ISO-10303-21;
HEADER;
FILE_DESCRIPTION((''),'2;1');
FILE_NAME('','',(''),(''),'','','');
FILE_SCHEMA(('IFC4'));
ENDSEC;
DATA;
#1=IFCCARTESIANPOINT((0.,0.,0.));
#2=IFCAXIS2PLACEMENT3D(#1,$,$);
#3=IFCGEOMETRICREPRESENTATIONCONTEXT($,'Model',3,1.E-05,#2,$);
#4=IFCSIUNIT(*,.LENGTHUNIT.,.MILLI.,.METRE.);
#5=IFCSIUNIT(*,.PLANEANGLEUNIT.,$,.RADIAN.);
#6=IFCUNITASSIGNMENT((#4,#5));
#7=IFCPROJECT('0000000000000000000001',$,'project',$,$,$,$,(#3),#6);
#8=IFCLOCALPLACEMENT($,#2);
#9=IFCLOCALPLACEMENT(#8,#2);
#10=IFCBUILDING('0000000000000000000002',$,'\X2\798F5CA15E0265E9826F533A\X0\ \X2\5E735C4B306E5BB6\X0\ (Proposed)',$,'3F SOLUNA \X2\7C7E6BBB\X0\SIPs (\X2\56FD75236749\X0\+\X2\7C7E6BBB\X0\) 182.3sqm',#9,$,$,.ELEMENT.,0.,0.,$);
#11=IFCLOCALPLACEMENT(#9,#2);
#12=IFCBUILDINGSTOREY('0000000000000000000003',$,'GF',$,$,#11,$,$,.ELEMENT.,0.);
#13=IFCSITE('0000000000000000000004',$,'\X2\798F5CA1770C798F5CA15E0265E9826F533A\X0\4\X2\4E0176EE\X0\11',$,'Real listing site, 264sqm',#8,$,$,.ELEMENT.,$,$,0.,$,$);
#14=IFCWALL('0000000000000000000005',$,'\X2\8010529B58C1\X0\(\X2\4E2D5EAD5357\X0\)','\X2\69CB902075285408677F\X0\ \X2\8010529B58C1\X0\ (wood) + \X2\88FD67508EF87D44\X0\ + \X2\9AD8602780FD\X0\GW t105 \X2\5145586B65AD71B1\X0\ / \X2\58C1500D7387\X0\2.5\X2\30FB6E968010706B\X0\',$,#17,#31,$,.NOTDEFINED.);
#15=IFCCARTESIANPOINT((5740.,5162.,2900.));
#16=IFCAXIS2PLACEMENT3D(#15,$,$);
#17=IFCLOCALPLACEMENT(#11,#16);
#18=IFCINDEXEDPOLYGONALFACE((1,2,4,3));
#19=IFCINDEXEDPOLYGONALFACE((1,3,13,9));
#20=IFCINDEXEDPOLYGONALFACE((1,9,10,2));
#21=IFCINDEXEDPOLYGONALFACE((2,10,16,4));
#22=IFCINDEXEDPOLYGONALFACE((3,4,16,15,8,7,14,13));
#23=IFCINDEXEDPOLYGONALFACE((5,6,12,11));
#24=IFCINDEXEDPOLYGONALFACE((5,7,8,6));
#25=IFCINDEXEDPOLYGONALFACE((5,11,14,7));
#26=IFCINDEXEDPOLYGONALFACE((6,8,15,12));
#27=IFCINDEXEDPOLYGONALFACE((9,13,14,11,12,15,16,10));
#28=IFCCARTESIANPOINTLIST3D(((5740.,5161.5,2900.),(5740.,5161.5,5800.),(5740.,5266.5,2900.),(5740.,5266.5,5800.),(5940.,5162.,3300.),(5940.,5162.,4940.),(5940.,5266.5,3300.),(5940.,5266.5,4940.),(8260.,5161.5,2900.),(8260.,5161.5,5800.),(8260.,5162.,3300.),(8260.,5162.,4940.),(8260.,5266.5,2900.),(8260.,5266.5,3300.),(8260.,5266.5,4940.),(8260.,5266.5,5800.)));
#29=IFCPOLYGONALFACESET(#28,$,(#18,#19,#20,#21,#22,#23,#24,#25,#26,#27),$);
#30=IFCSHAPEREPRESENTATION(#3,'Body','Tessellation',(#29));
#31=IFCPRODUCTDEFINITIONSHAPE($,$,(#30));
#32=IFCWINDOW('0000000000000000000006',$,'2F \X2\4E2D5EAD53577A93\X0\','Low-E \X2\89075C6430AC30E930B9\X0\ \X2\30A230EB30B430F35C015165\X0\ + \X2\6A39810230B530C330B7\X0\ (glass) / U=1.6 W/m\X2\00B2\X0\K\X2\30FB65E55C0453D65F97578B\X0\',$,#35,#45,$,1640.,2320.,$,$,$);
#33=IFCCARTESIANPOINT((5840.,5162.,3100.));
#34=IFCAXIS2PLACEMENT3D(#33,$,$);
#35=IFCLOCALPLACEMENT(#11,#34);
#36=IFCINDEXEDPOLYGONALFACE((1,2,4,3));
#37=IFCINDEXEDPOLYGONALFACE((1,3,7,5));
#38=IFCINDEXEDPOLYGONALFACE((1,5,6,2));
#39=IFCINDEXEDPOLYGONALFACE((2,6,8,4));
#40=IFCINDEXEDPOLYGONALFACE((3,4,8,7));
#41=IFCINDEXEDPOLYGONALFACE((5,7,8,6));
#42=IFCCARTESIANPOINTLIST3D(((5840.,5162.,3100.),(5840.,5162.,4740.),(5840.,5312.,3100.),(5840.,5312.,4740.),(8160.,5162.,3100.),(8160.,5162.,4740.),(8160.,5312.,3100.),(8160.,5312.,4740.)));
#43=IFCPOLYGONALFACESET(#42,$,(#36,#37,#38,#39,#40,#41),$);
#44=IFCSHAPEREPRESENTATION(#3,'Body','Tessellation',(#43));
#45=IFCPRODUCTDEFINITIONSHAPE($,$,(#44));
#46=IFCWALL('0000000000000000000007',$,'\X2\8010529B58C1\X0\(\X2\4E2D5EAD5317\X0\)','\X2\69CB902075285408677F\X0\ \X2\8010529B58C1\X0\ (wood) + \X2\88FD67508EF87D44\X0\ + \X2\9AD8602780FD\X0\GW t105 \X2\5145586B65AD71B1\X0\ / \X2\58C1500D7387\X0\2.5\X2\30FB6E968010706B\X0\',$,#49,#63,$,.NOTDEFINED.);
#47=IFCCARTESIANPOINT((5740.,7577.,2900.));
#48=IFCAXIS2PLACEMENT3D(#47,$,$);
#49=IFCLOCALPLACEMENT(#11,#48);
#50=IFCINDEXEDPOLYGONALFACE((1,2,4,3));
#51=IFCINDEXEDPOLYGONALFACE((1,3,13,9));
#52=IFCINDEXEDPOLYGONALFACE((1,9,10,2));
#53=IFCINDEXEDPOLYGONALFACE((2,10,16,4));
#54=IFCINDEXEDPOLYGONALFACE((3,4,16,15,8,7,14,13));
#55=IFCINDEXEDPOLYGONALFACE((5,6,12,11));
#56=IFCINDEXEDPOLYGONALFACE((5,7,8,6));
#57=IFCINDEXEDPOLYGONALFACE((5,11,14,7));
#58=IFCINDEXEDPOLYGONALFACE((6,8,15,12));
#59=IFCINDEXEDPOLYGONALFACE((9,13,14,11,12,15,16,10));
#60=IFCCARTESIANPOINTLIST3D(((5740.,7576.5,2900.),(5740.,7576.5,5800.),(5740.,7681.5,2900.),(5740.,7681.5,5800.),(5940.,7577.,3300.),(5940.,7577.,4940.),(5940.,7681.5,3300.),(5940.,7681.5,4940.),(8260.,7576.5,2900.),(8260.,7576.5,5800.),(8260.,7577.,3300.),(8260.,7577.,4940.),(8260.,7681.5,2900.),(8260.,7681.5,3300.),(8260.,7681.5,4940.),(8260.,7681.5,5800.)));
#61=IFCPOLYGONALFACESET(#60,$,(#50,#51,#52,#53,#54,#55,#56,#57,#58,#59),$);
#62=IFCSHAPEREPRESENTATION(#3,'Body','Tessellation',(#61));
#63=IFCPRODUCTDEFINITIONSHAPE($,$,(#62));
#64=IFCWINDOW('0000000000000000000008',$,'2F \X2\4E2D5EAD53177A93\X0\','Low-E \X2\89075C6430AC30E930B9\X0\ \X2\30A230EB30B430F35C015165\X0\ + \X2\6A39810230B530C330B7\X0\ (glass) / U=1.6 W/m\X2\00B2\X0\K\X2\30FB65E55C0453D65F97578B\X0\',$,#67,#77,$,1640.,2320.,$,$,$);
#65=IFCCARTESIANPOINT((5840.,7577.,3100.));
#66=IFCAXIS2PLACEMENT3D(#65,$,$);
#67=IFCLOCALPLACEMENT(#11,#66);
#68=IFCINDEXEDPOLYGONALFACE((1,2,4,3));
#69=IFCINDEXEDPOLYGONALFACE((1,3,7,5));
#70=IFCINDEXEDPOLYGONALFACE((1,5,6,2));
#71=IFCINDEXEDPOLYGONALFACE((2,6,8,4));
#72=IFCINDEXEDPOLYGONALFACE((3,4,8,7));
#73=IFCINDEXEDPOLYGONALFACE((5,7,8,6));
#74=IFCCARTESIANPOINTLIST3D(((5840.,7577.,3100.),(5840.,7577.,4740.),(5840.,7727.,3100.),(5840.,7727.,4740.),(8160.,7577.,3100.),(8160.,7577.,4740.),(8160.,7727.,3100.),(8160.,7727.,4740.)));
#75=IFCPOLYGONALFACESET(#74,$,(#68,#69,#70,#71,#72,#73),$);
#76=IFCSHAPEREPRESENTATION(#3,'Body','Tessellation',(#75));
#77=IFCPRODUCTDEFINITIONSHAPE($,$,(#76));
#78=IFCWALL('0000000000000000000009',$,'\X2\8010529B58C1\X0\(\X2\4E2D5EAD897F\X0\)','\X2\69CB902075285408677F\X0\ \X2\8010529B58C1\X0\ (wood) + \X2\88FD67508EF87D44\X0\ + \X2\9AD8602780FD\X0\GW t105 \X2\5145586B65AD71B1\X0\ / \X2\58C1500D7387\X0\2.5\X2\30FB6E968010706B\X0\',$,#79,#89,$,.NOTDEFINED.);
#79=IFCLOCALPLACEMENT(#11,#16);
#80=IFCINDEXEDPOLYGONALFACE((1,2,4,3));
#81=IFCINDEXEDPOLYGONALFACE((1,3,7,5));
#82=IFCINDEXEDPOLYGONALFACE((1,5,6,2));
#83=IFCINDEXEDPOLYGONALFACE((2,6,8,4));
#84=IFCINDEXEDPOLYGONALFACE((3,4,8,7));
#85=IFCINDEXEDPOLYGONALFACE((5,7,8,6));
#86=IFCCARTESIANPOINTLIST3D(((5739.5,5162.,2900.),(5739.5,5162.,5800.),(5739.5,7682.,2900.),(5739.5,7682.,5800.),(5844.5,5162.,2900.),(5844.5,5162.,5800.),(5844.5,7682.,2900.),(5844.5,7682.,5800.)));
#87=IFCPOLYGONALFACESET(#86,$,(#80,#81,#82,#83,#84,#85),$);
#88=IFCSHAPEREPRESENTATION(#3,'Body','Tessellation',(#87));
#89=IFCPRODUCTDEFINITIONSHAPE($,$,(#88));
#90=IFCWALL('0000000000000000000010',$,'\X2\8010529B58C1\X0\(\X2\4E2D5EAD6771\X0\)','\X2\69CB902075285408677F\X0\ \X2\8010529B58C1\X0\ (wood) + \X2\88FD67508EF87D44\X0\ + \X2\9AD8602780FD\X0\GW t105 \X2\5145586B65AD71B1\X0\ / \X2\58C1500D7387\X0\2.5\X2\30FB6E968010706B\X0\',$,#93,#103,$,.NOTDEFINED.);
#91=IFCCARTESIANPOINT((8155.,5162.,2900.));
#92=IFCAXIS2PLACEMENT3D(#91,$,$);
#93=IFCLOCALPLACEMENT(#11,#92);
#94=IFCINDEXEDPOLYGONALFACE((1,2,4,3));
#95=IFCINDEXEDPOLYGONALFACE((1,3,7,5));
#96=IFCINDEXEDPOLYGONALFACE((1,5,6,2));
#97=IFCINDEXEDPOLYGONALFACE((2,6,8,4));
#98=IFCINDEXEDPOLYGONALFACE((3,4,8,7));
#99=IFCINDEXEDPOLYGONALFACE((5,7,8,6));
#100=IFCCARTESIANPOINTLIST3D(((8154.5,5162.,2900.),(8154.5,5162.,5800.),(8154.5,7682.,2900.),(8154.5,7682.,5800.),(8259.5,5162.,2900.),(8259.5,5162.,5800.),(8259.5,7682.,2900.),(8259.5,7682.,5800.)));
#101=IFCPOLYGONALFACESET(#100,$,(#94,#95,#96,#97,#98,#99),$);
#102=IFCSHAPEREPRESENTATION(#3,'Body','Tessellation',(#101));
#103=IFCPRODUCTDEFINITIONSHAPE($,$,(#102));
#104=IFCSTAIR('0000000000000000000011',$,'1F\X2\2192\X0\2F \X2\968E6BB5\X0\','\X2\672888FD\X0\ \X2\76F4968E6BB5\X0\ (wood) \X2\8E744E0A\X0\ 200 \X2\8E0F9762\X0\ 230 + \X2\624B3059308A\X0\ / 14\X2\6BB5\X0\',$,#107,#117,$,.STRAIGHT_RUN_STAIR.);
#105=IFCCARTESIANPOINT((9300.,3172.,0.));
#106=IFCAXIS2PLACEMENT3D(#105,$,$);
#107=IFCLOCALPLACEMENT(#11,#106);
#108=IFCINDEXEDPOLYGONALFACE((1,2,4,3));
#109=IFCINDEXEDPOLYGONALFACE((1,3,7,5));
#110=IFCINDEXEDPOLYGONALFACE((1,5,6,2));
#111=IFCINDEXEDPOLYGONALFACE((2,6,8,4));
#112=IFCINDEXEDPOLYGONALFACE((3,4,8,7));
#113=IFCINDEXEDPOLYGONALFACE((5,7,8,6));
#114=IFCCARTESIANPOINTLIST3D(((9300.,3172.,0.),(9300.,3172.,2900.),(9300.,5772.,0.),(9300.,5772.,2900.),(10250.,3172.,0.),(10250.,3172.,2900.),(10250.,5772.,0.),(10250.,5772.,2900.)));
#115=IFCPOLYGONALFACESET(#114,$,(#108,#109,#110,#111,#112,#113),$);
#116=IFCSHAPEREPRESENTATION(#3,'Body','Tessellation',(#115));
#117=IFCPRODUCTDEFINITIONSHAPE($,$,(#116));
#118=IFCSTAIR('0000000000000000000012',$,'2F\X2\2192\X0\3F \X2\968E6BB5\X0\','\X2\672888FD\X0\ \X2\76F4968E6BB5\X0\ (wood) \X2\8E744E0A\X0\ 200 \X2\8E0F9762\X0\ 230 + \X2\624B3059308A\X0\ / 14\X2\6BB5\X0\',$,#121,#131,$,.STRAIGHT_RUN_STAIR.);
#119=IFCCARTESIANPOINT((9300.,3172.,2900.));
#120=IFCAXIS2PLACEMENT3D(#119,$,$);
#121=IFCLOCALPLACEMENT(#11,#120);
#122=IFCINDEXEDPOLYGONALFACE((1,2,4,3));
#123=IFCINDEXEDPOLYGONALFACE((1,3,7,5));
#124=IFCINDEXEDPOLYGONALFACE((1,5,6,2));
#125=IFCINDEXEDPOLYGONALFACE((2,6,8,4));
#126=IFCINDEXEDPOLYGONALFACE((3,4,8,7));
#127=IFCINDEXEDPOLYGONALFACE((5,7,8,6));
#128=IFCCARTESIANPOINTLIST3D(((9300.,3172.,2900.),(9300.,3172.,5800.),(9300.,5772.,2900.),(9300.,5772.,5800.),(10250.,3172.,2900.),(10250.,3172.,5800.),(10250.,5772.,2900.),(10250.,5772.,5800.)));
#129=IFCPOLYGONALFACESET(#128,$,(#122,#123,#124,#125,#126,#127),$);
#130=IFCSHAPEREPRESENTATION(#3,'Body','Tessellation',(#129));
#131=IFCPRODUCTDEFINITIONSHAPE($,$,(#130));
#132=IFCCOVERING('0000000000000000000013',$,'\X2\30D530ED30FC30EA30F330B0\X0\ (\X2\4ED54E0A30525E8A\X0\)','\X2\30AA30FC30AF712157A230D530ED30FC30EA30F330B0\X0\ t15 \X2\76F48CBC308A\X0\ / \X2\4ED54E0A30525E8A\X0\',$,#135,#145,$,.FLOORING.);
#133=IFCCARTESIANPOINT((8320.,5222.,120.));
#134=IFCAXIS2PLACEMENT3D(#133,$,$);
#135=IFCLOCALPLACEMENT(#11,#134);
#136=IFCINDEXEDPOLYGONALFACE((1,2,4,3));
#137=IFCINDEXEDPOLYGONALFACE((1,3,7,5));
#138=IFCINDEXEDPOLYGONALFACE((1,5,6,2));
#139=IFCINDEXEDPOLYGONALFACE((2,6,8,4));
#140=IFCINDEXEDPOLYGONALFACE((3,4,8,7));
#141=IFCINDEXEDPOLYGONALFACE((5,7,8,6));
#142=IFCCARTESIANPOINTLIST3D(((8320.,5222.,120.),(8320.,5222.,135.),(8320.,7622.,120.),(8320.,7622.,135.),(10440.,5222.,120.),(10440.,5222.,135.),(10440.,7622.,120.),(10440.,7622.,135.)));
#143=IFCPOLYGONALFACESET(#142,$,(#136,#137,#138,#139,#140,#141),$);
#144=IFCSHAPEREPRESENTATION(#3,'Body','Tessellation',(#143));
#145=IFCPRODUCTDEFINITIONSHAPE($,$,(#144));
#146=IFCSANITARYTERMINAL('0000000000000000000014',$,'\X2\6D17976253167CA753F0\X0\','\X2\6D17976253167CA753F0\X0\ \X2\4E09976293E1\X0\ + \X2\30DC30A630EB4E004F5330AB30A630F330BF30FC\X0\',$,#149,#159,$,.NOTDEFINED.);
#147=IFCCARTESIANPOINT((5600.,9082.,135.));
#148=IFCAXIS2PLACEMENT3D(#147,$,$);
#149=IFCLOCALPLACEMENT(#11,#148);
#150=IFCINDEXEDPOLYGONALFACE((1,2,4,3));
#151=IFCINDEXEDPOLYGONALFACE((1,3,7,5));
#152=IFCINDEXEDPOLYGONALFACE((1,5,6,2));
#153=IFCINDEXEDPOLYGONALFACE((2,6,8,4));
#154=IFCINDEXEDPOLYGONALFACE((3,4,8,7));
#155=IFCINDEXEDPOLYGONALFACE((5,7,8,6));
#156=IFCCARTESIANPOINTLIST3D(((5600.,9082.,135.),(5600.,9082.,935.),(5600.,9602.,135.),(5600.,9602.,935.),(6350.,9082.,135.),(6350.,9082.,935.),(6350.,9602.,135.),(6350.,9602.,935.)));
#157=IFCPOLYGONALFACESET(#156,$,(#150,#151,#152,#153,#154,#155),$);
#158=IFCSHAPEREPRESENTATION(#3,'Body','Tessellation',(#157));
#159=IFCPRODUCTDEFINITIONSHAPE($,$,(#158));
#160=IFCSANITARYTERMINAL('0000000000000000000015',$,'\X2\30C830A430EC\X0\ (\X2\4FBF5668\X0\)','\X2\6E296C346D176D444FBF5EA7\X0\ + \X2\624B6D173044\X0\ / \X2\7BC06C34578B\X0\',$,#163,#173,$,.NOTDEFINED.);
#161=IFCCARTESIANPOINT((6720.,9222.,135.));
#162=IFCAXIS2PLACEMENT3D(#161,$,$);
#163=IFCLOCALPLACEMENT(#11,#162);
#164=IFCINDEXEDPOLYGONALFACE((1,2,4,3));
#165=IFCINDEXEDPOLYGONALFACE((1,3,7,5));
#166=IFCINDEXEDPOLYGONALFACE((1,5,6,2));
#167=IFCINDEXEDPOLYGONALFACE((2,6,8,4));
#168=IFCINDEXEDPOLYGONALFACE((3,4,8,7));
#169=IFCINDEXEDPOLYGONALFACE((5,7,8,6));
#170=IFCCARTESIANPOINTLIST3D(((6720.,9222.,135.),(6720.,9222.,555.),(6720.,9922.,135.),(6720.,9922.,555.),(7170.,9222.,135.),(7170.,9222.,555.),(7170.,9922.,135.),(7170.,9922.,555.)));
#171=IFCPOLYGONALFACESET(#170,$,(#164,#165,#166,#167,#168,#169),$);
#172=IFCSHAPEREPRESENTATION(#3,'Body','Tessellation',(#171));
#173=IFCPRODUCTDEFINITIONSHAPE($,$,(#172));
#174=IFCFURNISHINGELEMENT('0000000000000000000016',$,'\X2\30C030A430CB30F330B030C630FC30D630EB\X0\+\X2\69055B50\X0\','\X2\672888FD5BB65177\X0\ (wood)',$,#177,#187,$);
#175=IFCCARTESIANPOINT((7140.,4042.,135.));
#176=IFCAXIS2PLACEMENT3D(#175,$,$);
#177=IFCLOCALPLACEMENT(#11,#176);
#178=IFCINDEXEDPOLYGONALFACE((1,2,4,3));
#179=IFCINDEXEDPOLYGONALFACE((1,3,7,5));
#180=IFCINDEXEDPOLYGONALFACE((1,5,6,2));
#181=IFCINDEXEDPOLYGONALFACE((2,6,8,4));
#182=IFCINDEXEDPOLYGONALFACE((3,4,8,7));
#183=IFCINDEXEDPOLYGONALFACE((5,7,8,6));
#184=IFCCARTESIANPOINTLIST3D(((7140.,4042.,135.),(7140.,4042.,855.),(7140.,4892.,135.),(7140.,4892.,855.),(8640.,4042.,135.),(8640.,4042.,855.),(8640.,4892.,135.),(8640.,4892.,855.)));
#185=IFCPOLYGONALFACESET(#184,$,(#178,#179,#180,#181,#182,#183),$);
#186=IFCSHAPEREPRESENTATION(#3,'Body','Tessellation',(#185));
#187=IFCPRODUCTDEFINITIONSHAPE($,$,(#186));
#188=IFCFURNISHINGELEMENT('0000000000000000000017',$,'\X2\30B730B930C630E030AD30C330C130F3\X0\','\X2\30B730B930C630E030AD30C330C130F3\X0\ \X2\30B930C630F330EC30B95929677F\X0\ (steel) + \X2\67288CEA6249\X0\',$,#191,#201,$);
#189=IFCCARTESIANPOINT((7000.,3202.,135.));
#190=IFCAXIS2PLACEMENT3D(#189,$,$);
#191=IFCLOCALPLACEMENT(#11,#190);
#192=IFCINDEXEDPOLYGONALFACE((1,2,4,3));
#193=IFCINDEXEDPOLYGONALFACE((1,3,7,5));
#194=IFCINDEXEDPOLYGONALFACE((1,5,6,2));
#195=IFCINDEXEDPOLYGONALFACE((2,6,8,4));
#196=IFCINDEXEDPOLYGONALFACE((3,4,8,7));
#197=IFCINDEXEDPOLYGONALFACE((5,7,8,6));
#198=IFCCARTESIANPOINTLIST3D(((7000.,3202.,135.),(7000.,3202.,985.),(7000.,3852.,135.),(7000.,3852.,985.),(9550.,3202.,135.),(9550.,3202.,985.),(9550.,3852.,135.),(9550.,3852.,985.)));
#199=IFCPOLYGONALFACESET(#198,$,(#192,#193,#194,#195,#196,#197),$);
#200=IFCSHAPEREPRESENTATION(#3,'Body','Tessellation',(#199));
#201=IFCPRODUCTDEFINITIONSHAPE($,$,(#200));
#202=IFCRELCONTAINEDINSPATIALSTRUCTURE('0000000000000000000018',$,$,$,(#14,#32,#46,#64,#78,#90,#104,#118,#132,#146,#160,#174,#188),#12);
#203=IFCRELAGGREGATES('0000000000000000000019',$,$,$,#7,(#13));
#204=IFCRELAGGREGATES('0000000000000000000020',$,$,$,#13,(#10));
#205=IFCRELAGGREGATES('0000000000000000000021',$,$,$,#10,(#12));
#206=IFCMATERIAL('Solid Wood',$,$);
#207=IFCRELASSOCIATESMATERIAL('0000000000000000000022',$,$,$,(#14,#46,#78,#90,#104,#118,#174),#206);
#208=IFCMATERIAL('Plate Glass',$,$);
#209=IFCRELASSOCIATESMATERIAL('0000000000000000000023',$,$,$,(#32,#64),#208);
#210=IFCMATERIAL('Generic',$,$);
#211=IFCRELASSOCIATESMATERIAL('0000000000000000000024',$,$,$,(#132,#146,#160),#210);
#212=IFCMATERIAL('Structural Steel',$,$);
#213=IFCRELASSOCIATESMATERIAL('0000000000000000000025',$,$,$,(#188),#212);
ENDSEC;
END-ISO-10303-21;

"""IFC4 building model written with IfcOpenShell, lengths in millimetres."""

from ifc_helpers import new_model, si_unit, frame, frame_2d, origin, place, context, project, spatial, rectangle, extrude, material, element, fill, save


model = new_model("IFC4")

# Units and contexts
model_context = context("Model", 3, precision=1e-05, world=origin())
ifc_project = project(units=[si_unit("LENGTHUNIT", "METRE", prefix="MILLI"), si_unit("PLANEANGLEUNIT", "RADIAN")], contexts=[model_context])

# Site, building, storey
site_placement = place(None, origin())
site = spatial("IfcSite", under=ifc_project, at=site_placement, Name="福岡県福岡市早良区4丁目11", ObjectType="Real listing site, 264sqm", CompositionType="ELEMENT", RefElevation=0.0)
building_placement = place(site_placement, origin())
building = spatial("IfcBuilding", under=site, at=building_placement, Name="福岡市早良区 平屋の家 (Proposed)", ObjectType="3F SOLUNA 籾殻SIPs (国産杉+籾殻) 182.3sqm", CompositionType="ELEMENT", ElevationOfRefHeight=0.0, ElevationOfTerrain=0.0)
storey_placement = place(building_placement, origin())
storey = spatial("IfcBuildingStorey", under=building, at=storey_placement, Name="GF", CompositionType="ELEMENT", Elevation=0.0)

# Shared definitions
ifc_material_1 = material(Name="Solid Wood")

# Shared definitions
ifc_material_2 = material(Name="Plate Glass")

# Walls, openings, windows
wall_1_placement = place(storey_placement, frame((5740.0, 5162.0, 2900.0)))
wall_1 = element("IfcWall", 1, at=wall_1_placement, inside=storey, material=ifc_material_1, Name="耐力壁(中庭南)", Description="構造用合板 耐力壁 (wood) + 製材軸組 + 高性能GW t105 充填断熱 / 壁倍率2.5・準耐火", PredefinedType="NOTDEFINED", context=model_context, shape_type="SweptSolid", body=[
    extrude(rectangle(XDim=2520.0, YDim=105.0, at=frame_2d((1260.0, 52.0))), frame((5740.0, 5162.0, 2900.0)), (0.0, 0.0, 1.0), 2900.0),
])
opening_1_placement = place(storey_placement, frame((5840.0, 5162.0, 3100.0)))
opening_1 = element("IfcOpeningElement", 2, at=opening_1_placement, cuts=wall_1, PredefinedType="NOTDEFINED", context=model_context, shape_type="SweptSolid", body=[
    extrude(rectangle(XDim=2320.0, YDim=150.0, at=frame_2d((1160.0, 75.0))), frame((5840.0, 5162.0, 3100.0)), (0.0, 0.0, 1.0), 1640.0),
])
window_1_placement = place(storey_placement, frame((5840.0, 5162.0, 3100.0)))
window_1 = element("IfcWindow", 3, at=window_1_placement, inside=storey, material=ifc_material_2, Name="2F 中庭南窓", Description="Low-E 複層ガラス アルゴン封入 + 樹脂サッシ (glass) / U=1.6 W/m²K・日射取得型", OverallHeight=1640.0, OverallWidth=2320.0, context=model_context, shape_type="SweptSolid", body=[
    extrude(rectangle(XDim=2320.0, YDim=150.0, at=frame_2d((1160.0, 75.0))), frame((5840.0, 5162.0, 3100.0)), (0.0, 0.0, 1.0), 1640.0),
])
fill(opening_1, window_1)
wall_2_placement = place(storey_placement, frame((5740.0, 7577.0, 2900.0)))
wall_2 = element("IfcWall", 4, at=wall_2_placement, inside=storey, material=ifc_material_1, Name="耐力壁(中庭北)", Description="構造用合板 耐力壁 (wood) + 製材軸組 + 高性能GW t105 充填断熱 / 壁倍率2.5・準耐火", PredefinedType="NOTDEFINED", context=model_context, shape_type="SweptSolid", body=[
    extrude(rectangle(XDim=2520.0, YDim=105.0, at=frame_2d((1260.0, 52.0))), frame((5740.0, 7577.0, 2900.0)), (0.0, 0.0, 1.0), 2900.0),
])
opening_2_placement = place(storey_placement, frame((5840.0, 7577.0, 3100.0)))
opening_2 = element("IfcOpeningElement", 5, at=opening_2_placement, cuts=wall_2, PredefinedType="NOTDEFINED", context=model_context, shape_type="SweptSolid", body=[
    extrude(rectangle(XDim=2320.0, YDim=150.0, at=frame_2d((1160.0, 75.0))), frame((5840.0, 7577.0, 3100.0)), (0.0, 0.0, 1.0), 1640.0),
])
window_2_placement = place(storey_placement, frame((5840.0, 7577.0, 3100.0)))
window_2 = element("IfcWindow", 6, at=window_2_placement, inside=storey, material=ifc_material_2, Name="2F 中庭北窓", Description="Low-E 複層ガラス アルゴン封入 + 樹脂サッシ (glass) / U=1.6 W/m²K・日射取得型", OverallHeight=1640.0, OverallWidth=2320.0, context=model_context, shape_type="SweptSolid", body=[
    extrude(rectangle(XDim=2320.0, YDim=150.0, at=frame_2d((1160.0, 75.0))), frame((5840.0, 7577.0, 3100.0)), (0.0, 0.0, 1.0), 1640.0),
])
fill(opening_2, window_2)

# Walls
wall_3_placement = place(storey_placement, frame((5740.0, 5162.0, 2900.0)))
element("IfcWall", 7, at=wall_3_placement, inside=storey, material=ifc_material_1, Name="耐力壁(中庭西)", Description="構造用合板 耐力壁 (wood) + 製材軸組 + 高性能GW t105 充填断熱 / 壁倍率2.5・準耐火", PredefinedType="NOTDEFINED", context=model_context, shape_type="SweptSolid", body=[
    extrude(rectangle(XDim=105.0, YDim=2520.0, at=frame_2d((52.0, 1260.0))), frame((5740.0, 5162.0, 2900.0)), (0.0, 0.0, 1.0), 2900.0),
])
wall_4_placement = place(storey_placement, frame((8155.0, 5162.0, 2900.0)))
element("IfcWall", 8, at=wall_4_placement, inside=storey, material=ifc_material_1, Name="耐力壁(中庭東)", Description="構造用合板 耐力壁 (wood) + 製材軸組 + 高性能GW t105 充填断熱 / 壁倍率2.5・準耐火", PredefinedType="NOTDEFINED", context=model_context, shape_type="SweptSolid", body=[
    extrude(rectangle(XDim=105.0, YDim=2520.0, at=frame_2d((52.0, 1260.0))), frame((8155.0, 5162.0, 2900.0)), (0.0, 0.0, 1.0), 2900.0),
])

# Stairs
stair_1_placement = place(storey_placement, frame((9300.0, 3172.0, 0.0)))
element("IfcStair", 9, at=stair_1_placement, inside=storey, material=ifc_material_1, Name="1F→2F 階段", Description="木製 直階段 (wood) 蹴上 200 踏面 230 + 手すり / 14段", PredefinedType="STRAIGHT_RUN_STAIR", context=model_context, shape_type="SweptSolid", body=[
    extrude(rectangle(XDim=950.0, YDim=2600.0, at=frame_2d((475.0, 1300.0))), frame((9300.0, 3172.0, 0.0)), (0.0, 0.0, 1.0), 2900.0),
])
stair_2_placement = place(storey_placement, frame((9300.0, 3172.0, 2900.0)))
element("IfcStair", 10, at=stair_2_placement, inside=storey, material=ifc_material_1, Name="2F→3F 階段", Description="木製 直階段 (wood) 蹴上 200 踏面 230 + 手すり / 14段", PredefinedType="STRAIGHT_RUN_STAIR", context=model_context, shape_type="SweptSolid", body=[
    extrude(rectangle(XDim=950.0, YDim=2600.0, at=frame_2d((475.0, 1300.0))), frame((9300.0, 3172.0, 2900.0)), (0.0, 0.0, 1.0), 2900.0),
])

# Covering
ifc_material_3 = material(Name="Generic")
covering_placement = place(storey_placement, frame((8320.0, 5222.0, 120.0)))
element("IfcCovering", 11, at=covering_placement, inside=storey, material=ifc_material_3, Name="フローリング (仕上げ床)", Description="オーク無垢フローリング t15 直貼り / 仕上げ床", PredefinedType="FLOORING", context=model_context, shape_type="SweptSolid", body=[
    extrude(rectangle(XDim=2120.0, YDim=2400.0, at=frame_2d((1060.0, 1200.0))), frame((8320.0, 5222.0, 120.0)), (0.0, 0.0, 1.0), 15.0),
])

# Sanitary terminals
sanitary_terminal_1_placement = place(storey_placement, frame((5600.0, 9082.0, 135.0)))
element("IfcSanitaryTerminal", 12, at=sanitary_terminal_1_placement, inside=storey, material=ifc_material_3, Name="洗面化粧台", Description="洗面化粧台 三面鏡 + ボウル一体カウンター", PredefinedType="NOTDEFINED", context=model_context, shape_type="SweptSolid", body=[
    extrude(rectangle(XDim=750.0, YDim=520.0, at=frame_2d((375.0, 260.0))), frame((5600.0, 9082.0, 135.0)), (0.0, 0.0, 1.0), 800.0),
])
sanitary_terminal_2_placement = place(storey_placement, frame((6720.0, 9222.0, 135.0)))
element("IfcSanitaryTerminal", 13, at=sanitary_terminal_2_placement, inside=storey, material=ifc_material_3, Name="トイレ (便器)", Description="温水洗浄便座 + 手洗い / 節水型", PredefinedType="NOTDEFINED", context=model_context, shape_type="SweptSolid", body=[
    extrude(rectangle(XDim=450.0, YDim=700.0, at=frame_2d((225.0, 350.0))), frame((6720.0, 9222.0, 135.0)), (0.0, 0.0, 1.0), 420.0),
])

# Furnishing elements
furnishing_1_placement = place(storey_placement, frame((7140.0, 4042.0, 135.0)))
element("IfcFurnishingElement", 14, at=furnishing_1_placement, inside=storey, material=ifc_material_1, Name="ダイニングテーブル+椅子", Description="木製家具 (wood)", context=model_context, shape_type="SweptSolid", body=[
    extrude(rectangle(XDim=1500.0, YDim=850.0, at=frame_2d((750.0, 425.0))), frame((7140.0, 4042.0, 135.0)), (0.0, 0.0, 1.0), 720.0),
])
ifc_material_4 = material(Name="Structural Steel")
furnishing_2_placement = place(storey_placement, frame((7000.0, 3202.0, 135.0)))
element("IfcFurnishingElement", 15, at=furnishing_2_placement, inside=storey, material=ifc_material_4, Name="システムキッチン", Description="システムキッチン ステンレス天板 (steel) + 木質扉", context=model_context, shape_type="SweptSolid", body=[
    extrude(rectangle(XDim=2550.0, YDim=650.0, at=frame_2d((1275.0, 325.0))), frame((7000.0, 3202.0, 135.0)), (0.0, 0.0, 1.0), 850.0),
])

save(model, "model.ifc")
